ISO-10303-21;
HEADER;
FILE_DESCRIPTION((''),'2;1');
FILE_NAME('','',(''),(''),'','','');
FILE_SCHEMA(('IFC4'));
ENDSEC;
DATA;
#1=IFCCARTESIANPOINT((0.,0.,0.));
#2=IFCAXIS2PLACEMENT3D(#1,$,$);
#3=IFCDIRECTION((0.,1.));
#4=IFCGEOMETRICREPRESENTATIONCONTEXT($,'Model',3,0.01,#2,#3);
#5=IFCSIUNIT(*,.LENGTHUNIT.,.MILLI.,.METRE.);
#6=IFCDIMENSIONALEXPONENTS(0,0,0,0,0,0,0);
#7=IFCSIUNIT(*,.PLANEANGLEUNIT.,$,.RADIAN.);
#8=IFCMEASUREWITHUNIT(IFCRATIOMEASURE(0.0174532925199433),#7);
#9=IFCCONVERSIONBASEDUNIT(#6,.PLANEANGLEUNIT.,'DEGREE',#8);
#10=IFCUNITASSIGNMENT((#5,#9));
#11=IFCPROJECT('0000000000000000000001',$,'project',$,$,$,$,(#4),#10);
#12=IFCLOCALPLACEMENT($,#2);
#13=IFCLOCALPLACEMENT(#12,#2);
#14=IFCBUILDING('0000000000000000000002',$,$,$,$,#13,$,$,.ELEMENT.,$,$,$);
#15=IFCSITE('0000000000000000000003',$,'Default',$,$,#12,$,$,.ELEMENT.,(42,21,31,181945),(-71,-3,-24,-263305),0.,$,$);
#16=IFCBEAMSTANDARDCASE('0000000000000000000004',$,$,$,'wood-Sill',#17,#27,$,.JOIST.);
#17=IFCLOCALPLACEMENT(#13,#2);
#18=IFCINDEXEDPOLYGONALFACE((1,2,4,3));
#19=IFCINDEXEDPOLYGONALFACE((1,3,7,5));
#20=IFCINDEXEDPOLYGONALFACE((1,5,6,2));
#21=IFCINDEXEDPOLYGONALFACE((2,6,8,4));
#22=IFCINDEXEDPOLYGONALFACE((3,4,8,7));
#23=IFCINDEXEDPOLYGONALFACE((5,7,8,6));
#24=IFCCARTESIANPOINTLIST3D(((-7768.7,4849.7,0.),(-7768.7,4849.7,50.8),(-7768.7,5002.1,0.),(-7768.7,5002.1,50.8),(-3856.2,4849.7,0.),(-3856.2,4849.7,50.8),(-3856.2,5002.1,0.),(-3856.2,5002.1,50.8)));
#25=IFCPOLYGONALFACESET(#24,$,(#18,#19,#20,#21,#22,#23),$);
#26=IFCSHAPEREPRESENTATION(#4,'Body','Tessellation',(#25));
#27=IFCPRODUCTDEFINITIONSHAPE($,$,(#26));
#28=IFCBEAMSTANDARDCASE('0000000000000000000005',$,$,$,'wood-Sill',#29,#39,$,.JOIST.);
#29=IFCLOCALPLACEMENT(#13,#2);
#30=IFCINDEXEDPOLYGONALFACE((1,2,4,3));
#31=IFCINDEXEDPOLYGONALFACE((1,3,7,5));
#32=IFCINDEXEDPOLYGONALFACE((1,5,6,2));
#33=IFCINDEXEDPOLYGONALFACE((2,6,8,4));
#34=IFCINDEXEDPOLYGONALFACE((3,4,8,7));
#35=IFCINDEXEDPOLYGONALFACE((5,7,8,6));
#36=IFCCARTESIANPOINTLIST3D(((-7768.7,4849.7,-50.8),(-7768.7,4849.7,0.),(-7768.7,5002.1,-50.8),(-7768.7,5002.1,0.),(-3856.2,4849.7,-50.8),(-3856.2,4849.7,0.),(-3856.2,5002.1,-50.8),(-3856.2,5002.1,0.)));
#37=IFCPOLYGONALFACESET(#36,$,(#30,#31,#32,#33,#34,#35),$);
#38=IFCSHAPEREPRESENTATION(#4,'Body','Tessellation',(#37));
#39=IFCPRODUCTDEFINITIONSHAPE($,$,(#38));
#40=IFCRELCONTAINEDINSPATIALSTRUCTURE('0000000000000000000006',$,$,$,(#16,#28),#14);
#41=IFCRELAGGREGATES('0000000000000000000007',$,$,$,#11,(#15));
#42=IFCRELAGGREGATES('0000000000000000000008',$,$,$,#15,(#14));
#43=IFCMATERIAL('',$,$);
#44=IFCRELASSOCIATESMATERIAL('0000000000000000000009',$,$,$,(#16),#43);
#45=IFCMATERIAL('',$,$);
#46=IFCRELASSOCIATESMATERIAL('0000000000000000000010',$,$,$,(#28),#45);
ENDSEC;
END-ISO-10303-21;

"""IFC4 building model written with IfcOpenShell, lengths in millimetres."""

from ifc_helpers import new_model, entity, si_unit, converted_unit, direction, frame, origin, place, context, project, spatial, rectangle, extrude, material, element, save


model = new_model("IFC4")

# Units and contexts
model_context = context("Model", 3, precision=0.01, world=origin(), true_north=direction((0.0, 1.0)))
ifc_project = project(units=[si_unit("LENGTHUNIT", "METRE", prefix="MILLI"), converted_unit("PLANEANGLEUNIT", "DEGREE", entity("IfcRatioMeasure", 0.0174532925199433), si_unit("PLANEANGLEUNIT", "RADIAN"), dimensions=[0, 0, 0, 0, 0, 0, 0])], contexts=[model_context])

# Site, building
site_placement = place(None, origin())
site = spatial("IfcSite", under=ifc_project, at=site_placement, Name="Default", CompositionType="ELEMENT", RefLatitude=(42, 21, 31, 181945), RefLongitude=(-71, -3, -24, -263305), RefElevation=0.0)
building_placement = place(site_placement, origin())
building = spatial("IfcBuilding", under=site, at=building_placement, CompositionType="ELEMENT")

# Shared definitions
placement_1 = place(building_placement, origin())
placement_2 = place(placement_1, frame((-5812.4, 2969.7, 0.0), z_axis=(0.0, 0.0, 1.0), x_axis=(0.0, 1.0, 0.0)))

# Beams
ifc_material_1 = material(Name="")
beam_1_placement = place(placement_2, frame((1956.2, 0.0, 0.0), z_axis=(0.0, 0.0, 1.0), x_axis=(0.0, 1.0, 0.0)))
element("IfcBeamStandardCase", 1, at=beam_1_placement, inside=building, material=ifc_material_1, ObjectType="wood-Sill", PredefinedType="JOIST", context=model_context, shape_type="SweptSolid", body=[
    extrude(rectangle(XDim=3912.5, YDim=152.4), origin(), (0.0, 0.0, 1.0), 50.8),
])
ifc_material_2 = material(Name="")
beam_2_placement = place(placement_2, frame((1956.2, 0.0, -50.8), z_axis=(0.0, 0.0, 1.0), x_axis=(0.0, 1.0, 0.0)))
element("IfcBeamStandardCase", 2, at=beam_2_placement, inside=building, material=ifc_material_2, ObjectType="wood-Sill", PredefinedType="JOIST", context=model_context, shape_type="SweptSolid", body=[
    extrude(rectangle(XDim=3912.5, YDim=152.4), origin(), (0.0, 0.0, 1.0), 50.8),
])

save(model, "model.ifc")
